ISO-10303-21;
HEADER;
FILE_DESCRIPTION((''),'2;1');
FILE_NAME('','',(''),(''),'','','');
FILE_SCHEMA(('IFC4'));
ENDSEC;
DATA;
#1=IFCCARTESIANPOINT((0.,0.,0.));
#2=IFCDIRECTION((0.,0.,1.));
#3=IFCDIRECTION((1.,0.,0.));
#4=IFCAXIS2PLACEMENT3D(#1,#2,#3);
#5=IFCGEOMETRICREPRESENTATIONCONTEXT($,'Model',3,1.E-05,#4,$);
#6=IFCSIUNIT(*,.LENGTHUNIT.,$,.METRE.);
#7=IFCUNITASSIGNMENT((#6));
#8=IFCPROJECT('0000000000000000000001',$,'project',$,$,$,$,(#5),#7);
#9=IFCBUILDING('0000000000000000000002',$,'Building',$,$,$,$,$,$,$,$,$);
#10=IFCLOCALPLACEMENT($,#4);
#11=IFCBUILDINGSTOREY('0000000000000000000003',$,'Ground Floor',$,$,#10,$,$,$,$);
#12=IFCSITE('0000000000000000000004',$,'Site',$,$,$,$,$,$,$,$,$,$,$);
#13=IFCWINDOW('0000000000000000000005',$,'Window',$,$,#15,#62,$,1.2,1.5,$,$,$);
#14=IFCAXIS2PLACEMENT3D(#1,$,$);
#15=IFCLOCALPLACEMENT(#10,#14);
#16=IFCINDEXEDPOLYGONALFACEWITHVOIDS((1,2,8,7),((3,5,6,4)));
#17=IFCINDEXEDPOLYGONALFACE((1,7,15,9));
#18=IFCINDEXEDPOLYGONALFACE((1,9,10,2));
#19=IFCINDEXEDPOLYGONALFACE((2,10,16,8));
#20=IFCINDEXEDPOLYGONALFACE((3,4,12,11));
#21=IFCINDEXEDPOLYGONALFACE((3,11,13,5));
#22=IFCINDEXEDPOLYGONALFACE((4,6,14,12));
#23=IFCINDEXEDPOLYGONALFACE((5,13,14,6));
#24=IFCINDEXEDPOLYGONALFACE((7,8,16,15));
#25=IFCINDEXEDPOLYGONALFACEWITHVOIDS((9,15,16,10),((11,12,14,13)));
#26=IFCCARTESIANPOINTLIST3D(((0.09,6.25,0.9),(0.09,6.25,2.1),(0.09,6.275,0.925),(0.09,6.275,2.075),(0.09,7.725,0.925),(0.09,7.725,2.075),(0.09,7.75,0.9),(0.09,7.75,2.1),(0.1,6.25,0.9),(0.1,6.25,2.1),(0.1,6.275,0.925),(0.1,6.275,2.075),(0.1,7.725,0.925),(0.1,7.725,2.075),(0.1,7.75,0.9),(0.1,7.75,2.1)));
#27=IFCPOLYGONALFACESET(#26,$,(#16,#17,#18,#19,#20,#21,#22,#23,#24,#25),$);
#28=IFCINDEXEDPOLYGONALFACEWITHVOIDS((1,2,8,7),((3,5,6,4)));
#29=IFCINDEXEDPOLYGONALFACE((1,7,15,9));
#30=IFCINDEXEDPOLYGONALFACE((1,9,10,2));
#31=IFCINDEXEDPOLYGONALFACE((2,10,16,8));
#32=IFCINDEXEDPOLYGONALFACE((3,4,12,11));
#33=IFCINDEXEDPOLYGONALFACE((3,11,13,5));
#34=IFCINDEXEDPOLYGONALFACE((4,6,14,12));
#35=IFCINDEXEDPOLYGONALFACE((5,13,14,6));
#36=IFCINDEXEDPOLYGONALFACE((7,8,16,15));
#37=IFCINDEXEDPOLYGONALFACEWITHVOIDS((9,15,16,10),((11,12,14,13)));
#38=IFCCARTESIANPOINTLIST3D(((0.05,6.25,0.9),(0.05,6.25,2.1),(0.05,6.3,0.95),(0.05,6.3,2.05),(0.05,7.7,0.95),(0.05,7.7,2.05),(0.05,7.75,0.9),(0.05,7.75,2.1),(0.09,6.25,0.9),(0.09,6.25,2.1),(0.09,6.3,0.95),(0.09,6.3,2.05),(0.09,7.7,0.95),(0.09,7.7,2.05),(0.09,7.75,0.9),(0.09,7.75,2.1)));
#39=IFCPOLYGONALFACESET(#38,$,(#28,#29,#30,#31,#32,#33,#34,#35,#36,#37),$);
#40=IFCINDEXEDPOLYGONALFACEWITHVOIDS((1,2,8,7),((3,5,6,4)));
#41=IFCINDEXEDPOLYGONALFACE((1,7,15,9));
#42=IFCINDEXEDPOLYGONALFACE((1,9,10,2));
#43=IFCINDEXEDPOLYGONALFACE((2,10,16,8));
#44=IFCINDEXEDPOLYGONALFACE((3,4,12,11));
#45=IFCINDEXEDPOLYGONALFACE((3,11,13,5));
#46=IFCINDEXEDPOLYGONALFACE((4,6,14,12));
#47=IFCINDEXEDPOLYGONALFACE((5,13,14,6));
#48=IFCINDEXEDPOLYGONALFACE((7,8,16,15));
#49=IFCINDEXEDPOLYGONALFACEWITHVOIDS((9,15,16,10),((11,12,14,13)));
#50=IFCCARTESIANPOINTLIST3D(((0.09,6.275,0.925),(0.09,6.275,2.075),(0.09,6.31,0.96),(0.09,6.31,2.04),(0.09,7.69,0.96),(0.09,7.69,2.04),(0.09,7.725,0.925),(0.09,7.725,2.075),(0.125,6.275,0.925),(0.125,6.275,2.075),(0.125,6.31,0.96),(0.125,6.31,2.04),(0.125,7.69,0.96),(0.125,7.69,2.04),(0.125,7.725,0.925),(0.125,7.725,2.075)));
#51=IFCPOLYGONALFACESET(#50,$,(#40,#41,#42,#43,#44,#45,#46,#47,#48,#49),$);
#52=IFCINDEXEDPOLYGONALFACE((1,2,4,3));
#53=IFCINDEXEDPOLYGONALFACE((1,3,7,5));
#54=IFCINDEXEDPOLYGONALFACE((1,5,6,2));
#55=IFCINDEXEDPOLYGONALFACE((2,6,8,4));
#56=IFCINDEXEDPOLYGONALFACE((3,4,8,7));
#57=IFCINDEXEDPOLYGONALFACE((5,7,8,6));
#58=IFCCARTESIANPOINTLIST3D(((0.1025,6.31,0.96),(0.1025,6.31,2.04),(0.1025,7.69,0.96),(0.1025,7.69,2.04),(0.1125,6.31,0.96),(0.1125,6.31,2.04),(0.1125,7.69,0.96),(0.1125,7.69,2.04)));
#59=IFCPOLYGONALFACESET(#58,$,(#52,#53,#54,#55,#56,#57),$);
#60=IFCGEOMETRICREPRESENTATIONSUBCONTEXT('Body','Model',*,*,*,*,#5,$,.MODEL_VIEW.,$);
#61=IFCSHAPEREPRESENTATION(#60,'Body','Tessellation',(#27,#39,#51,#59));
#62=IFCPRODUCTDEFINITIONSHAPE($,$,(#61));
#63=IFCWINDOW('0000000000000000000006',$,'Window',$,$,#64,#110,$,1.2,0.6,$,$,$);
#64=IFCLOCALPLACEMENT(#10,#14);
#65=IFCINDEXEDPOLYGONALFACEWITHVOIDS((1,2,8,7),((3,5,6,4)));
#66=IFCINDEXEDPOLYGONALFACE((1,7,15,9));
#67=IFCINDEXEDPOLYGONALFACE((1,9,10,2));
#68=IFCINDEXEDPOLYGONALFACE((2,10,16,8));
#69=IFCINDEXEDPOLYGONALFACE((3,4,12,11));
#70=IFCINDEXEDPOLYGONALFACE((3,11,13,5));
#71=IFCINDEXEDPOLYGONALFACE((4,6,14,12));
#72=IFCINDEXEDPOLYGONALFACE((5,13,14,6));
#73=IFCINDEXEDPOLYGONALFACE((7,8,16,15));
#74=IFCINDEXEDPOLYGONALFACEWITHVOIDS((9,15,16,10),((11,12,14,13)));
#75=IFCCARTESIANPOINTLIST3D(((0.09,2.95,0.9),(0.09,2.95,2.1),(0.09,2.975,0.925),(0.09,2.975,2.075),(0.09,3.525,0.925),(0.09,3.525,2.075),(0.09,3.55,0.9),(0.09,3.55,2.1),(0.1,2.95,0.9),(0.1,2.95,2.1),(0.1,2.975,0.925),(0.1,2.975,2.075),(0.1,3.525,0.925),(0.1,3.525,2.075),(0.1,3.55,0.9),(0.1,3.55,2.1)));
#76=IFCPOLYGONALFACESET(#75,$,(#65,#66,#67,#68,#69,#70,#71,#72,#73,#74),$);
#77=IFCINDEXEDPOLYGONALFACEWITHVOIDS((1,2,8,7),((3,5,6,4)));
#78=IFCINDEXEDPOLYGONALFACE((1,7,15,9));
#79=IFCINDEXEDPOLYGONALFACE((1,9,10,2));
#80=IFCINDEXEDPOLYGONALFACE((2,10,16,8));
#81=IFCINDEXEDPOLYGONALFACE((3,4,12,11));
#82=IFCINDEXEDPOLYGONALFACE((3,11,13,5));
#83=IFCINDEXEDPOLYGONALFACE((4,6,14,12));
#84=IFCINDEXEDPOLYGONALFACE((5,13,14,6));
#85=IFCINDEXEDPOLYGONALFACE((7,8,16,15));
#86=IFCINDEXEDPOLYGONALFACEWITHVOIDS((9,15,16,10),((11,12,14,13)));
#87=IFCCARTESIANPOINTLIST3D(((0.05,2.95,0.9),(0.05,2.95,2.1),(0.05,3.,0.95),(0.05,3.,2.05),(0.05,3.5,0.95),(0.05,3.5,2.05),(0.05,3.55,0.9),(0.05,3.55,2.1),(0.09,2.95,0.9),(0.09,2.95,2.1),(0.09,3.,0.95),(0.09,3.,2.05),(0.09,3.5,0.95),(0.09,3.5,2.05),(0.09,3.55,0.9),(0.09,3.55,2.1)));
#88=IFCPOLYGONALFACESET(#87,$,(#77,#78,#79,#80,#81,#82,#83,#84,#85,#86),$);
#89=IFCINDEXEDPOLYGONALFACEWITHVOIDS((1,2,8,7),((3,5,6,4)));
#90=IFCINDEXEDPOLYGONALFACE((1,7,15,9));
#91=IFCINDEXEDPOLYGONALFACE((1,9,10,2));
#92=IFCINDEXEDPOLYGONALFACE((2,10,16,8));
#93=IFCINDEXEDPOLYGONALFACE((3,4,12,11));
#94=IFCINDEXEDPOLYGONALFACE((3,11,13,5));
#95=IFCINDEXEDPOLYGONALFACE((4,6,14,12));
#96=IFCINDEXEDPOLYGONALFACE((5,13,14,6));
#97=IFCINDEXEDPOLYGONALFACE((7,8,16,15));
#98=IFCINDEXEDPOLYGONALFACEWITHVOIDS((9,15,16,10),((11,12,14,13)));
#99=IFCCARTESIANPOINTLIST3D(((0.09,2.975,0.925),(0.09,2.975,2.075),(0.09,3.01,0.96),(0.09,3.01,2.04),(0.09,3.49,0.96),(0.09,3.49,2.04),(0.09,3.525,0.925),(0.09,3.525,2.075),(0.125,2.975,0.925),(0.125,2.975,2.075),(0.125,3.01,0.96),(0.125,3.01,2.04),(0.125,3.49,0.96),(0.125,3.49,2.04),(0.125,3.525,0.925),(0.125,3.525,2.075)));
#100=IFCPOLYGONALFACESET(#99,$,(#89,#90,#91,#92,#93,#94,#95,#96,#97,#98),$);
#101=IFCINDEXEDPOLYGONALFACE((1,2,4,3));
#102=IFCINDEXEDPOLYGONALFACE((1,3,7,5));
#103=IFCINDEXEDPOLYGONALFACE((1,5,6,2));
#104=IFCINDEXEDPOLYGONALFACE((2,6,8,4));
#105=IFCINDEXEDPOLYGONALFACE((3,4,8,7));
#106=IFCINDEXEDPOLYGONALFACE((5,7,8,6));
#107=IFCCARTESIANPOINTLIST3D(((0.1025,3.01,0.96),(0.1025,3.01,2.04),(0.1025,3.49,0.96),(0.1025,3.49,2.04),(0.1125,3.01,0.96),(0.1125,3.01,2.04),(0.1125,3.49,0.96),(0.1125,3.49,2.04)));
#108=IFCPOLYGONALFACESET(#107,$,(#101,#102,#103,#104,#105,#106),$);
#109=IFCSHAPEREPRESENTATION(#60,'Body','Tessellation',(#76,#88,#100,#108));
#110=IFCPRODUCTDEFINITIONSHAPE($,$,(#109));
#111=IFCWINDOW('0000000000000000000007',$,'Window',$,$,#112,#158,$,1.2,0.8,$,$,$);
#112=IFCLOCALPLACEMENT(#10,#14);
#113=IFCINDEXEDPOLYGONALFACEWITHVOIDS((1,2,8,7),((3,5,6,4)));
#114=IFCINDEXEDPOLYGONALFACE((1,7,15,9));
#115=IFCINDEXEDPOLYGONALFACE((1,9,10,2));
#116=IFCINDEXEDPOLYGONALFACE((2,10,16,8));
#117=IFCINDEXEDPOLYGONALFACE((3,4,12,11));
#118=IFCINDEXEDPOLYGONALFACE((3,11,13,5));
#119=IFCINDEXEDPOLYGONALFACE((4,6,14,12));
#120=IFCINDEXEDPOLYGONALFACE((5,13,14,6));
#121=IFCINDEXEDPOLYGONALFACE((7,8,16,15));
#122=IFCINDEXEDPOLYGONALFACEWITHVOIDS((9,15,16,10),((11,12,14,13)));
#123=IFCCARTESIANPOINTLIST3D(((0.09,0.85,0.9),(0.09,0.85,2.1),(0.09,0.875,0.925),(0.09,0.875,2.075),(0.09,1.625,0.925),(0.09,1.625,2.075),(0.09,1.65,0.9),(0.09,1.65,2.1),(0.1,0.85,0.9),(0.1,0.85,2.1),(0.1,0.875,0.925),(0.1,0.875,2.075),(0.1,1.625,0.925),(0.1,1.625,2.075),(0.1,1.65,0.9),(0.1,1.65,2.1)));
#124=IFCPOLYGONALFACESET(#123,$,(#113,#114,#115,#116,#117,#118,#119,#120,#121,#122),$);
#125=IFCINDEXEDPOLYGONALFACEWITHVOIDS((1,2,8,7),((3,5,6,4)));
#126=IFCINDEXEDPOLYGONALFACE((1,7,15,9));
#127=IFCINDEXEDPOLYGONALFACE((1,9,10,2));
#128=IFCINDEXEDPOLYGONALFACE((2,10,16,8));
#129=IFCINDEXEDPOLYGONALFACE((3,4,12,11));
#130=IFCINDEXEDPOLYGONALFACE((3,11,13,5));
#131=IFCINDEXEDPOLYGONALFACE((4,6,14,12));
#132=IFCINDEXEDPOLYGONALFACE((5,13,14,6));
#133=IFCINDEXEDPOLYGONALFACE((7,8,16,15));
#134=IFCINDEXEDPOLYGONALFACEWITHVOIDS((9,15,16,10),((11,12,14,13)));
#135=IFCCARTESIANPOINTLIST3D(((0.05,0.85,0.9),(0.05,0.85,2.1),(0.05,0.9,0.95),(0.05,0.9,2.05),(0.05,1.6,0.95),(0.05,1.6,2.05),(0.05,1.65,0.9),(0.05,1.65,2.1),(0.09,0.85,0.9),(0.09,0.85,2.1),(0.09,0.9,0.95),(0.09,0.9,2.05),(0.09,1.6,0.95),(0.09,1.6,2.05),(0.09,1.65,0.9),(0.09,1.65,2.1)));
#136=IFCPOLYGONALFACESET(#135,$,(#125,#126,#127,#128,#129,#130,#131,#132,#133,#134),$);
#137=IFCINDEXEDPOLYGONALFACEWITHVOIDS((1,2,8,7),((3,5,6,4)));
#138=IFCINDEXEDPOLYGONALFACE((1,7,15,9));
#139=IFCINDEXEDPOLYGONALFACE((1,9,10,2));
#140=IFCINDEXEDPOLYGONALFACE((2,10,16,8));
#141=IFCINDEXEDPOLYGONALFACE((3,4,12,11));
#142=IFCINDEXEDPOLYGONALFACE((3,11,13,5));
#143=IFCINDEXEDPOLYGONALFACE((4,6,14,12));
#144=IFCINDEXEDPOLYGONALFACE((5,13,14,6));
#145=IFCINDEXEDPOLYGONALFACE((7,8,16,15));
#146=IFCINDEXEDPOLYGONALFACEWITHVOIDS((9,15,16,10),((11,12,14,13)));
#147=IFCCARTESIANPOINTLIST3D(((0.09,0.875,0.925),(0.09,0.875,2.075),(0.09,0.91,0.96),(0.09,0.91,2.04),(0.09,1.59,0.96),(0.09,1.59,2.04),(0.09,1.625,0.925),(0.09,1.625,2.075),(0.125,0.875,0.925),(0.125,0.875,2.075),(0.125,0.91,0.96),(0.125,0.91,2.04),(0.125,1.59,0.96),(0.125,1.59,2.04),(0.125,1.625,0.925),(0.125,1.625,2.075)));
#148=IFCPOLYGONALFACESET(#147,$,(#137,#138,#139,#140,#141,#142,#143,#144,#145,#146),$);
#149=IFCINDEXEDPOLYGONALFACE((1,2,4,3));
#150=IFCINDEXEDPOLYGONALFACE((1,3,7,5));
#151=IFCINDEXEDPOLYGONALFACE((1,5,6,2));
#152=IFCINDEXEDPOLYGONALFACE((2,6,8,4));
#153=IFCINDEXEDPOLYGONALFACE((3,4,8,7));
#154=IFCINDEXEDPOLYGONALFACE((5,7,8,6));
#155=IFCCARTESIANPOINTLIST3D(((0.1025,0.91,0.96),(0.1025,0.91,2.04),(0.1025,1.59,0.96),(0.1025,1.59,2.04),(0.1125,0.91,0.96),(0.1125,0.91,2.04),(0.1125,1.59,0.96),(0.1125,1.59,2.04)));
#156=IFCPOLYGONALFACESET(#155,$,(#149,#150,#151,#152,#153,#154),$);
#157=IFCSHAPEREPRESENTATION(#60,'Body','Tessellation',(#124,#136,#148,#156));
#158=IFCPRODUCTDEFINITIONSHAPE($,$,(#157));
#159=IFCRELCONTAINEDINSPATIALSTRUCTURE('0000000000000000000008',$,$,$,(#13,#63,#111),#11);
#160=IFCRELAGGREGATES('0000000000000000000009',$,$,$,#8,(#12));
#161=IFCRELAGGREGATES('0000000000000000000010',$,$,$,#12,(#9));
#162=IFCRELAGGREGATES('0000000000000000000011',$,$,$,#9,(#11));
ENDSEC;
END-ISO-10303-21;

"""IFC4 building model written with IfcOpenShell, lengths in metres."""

from ifc_helpers import new_model, si_unit, frame, origin_with_axes, place, context, subcontext, project, spatial, line, indexed_curve, outline, extrude, element, save


model = new_model("IFC4")

# Units and contexts
model_context = context("Model", 3, precision=1e-05, world=origin_with_axes())
body_context = subcontext(model_context, "Body", "Model", "MODEL_VIEW")
ifc_project = project(units=[si_unit("LENGTHUNIT", "METRE")], contexts=[model_context])

# Site, building, storey
site = spatial("IfcSite", under=ifc_project, Name="Site")
building = spatial("IfcBuilding", under=site, Name="Building")
storey_placement = place(None, origin_with_axes())
storey = spatial("IfcBuildingStorey", under=building, at=storey_placement, Name="Ground Floor")

# Windows
window_1_placement = place(storey_placement, frame((0.0, 7.75, 0.9), z_axis=(0.0, 0.0, 1.0), x_axis=(0.0, -1.0, 0.0)))
element("IfcWindow", 1, at=window_1_placement, inside=storey, Name="Window", OverallHeight=1.2, OverallWidth=1.5, context=body_context, shape_type="SweptSolid", body=[
    extrude(outline(indexed_curve([(0.0, 0.0), (1.5, 0.0), (1.5, 1.2), (0.0, 1.2)], segments=[line(1, 2, 3, 4, 1)]), holes=[indexed_curve([(0.025, 0.025), (1.475, 0.025), (1.475, 1.175), (0.025, 1.175)], segments=[line(1, 2, 3, 4, 1)])]), frame((0.0, 0.09, 0.0), z_axis=(0.0, -1.0, 0.0), x_axis=(1.0, 0.0, 0.0)), (0.0, 0.0, -1.0), 0.01),
    extrude(outline(indexed_curve([(0.0, 0.0), (1.5, 0.0), (1.5, 1.2), (0.0, 1.2)], segments=[line(1, 2, 3, 4, 1)]), holes=[indexed_curve([(0.05, 0.05), (1.45, 0.05), (1.45, 1.15), (0.05, 1.15)], segments=[line(1, 2, 3, 4, 1)])]), frame((0.0, 0.05, 0.0), z_axis=(0.0, -1.0, 0.0), x_axis=(1.0, 0.0, 0.0)), (0.0, 0.0, -1.0), 0.04),
    extrude(outline(indexed_curve([(0.0, 0.0), (1.45, 0.0), (1.45, 1.15), (0.0, 1.15)], segments=[line(1, 2, 3, 4, 1)]), holes=[indexed_curve([(0.035, 0.035), (1.415, 0.035), (1.415, 1.115), (0.035, 1.115)], segments=[line(1, 2, 3, 4, 1)])]), frame((0.025, 0.09, 0.025), z_axis=(0.0, -1.0, 0.0), x_axis=(1.0, 0.0, 0.0)), (0.0, 0.0, -1.0), 0.035),
    extrude(outline(indexed_curve([(0.035, 0.035), (1.415, 0.035), (1.415, 1.115), (0.035, 1.115)], segments=[line(1, 2, 3, 4, 1)])), frame((0.025, 0.1025, 0.025), z_axis=(0.0, -1.0, 0.0), x_axis=(1.0, 0.0, 0.0)), (0.0, 0.0, -1.0), 0.01),
])
window_2_placement = place(storey_placement, frame((0.0, 3.55, 0.9), z_axis=(0.0, 0.0, 1.0), x_axis=(0.0, -1.0, 0.0)))
element("IfcWindow", 2, at=window_2_placement, inside=storey, Name="Window", OverallHeight=1.2, OverallWidth=0.6, context=body_context, shape_type="SweptSolid", body=[
    extrude(outline(indexed_curve([(0.0, 0.0), (0.6, 0.0), (0.6, 1.2), (0.0, 1.2)], segments=[line(1, 2, 3, 4, 1)]), holes=[indexed_curve([(0.025, 0.025), (0.575, 0.025), (0.575, 1.175), (0.025, 1.175)], segments=[line(1, 2, 3, 4, 1)])]), frame((0.0, 0.09, 0.0), z_axis=(0.0, -1.0, 0.0), x_axis=(1.0, 0.0, 0.0)), (0.0, 0.0, -1.0), 0.01),
    extrude(outline(indexed_curve([(0.0, 0.0), (0.6, 0.0), (0.6, 1.2), (0.0, 1.2)], segments=[line(1, 2, 3, 4, 1)]), holes=[indexed_curve([(0.05, 0.05), (0.55, 0.05), (0.55, 1.15), (0.05, 1.15)], segments=[line(1, 2, 3, 4, 1)])]), frame((0.0, 0.05, 0.0), z_axis=(0.0, -1.0, 0.0), x_axis=(1.0, 0.0, 0.0)), (0.0, 0.0, -1.0), 0.04),
    extrude(outline(indexed_curve([(0.0, 0.0), (0.55, 0.0), (0.55, 1.15), (0.0, 1.15)], segments=[line(1, 2, 3, 4, 1)]), holes=[indexed_curve([(0.035, 0.035), (0.515, 0.035), (0.515, 1.115), (0.035, 1.115)], segments=[line(1, 2, 3, 4, 1)])]), frame((0.025, 0.09, 0.025), z_axis=(0.0, -1.0, 0.0), x_axis=(1.0, 0.0, 0.0)), (0.0, 0.0, -1.0), 0.035),
    extrude(outline(indexed_curve([(0.035, 0.035), (0.515, 0.035), (0.515, 1.115), (0.035, 1.115)], segments=[line(1, 2, 3, 4, 1)])), frame((0.025, 0.1025, 0.025), z_axis=(0.0, -1.0, 0.0), x_axis=(1.0, 0.0, 0.0)), (0.0, 0.0, -1.0), 0.01),
])
window_3_placement = place(storey_placement, frame((0.0, 1.65, 0.9), z_axis=(0.0, 0.0, 1.0), x_axis=(0.0, -1.0, 0.0)))
element("IfcWindow", 3, at=window_3_placement, inside=storey, Name="Window", OverallHeight=1.2, OverallWidth=0.8, context=body_context, shape_type="SweptSolid", body=[
    extrude(outline(indexed_curve([(0.0, 0.0), (0.8, 0.0), (0.8, 1.2), (0.0, 1.2)], segments=[line(1, 2, 3, 4, 1)]), holes=[indexed_curve([(0.025, 0.025), (0.775, 0.025), (0.775, 1.175), (0.025, 1.175)], segments=[line(1, 2, 3, 4, 1)])]), frame((0.0, 0.09, 0.0), z_axis=(0.0, -1.0, 0.0), x_axis=(1.0, 0.0, 0.0)), (0.0, 0.0, -1.0), 0.01),
    extrude(outline(indexed_curve([(0.0, 0.0), (0.8, 0.0), (0.8, 1.2), (0.0, 1.2)], segments=[line(1, 2, 3, 4, 1)]), holes=[indexed_curve([(0.05, 0.05), (0.75, 0.05), (0.75, 1.15), (0.05, 1.15)], segments=[line(1, 2, 3, 4, 1)])]), frame((0.0, 0.05, 0.0), z_axis=(0.0, -1.0, 0.0), x_axis=(1.0, 0.0, 0.0)), (0.0, 0.0, -1.0), 0.04),
    extrude(outline(indexed_curve([(0.0, 0.0), (0.75, 0.0), (0.75, 1.15), (0.0, 1.15)], segments=[line(1, 2, 3, 4, 1)]), holes=[indexed_curve([(0.035, 0.035), (0.715, 0.035), (0.715, 1.115), (0.035, 1.115)], segments=[line(1, 2, 3, 4, 1)])]), frame((0.025, 0.09, 0.025), z_axis=(0.0, -1.0, 0.0), x_axis=(1.0, 0.0, 0.0)), (0.0, 0.0, -1.0), 0.035),
    extrude(outline(indexed_curve([(0.035, 0.035), (0.715, 0.035), (0.715, 1.115), (0.035, 1.115)], segments=[line(1, 2, 3, 4, 1)])), frame((0.025, 0.1025, 0.025), z_axis=(0.0, -1.0, 0.0), x_axis=(1.0, 0.0, 0.0)), (0.0, 0.0, -1.0), 0.01),
])

save(model, "model.ifc")
